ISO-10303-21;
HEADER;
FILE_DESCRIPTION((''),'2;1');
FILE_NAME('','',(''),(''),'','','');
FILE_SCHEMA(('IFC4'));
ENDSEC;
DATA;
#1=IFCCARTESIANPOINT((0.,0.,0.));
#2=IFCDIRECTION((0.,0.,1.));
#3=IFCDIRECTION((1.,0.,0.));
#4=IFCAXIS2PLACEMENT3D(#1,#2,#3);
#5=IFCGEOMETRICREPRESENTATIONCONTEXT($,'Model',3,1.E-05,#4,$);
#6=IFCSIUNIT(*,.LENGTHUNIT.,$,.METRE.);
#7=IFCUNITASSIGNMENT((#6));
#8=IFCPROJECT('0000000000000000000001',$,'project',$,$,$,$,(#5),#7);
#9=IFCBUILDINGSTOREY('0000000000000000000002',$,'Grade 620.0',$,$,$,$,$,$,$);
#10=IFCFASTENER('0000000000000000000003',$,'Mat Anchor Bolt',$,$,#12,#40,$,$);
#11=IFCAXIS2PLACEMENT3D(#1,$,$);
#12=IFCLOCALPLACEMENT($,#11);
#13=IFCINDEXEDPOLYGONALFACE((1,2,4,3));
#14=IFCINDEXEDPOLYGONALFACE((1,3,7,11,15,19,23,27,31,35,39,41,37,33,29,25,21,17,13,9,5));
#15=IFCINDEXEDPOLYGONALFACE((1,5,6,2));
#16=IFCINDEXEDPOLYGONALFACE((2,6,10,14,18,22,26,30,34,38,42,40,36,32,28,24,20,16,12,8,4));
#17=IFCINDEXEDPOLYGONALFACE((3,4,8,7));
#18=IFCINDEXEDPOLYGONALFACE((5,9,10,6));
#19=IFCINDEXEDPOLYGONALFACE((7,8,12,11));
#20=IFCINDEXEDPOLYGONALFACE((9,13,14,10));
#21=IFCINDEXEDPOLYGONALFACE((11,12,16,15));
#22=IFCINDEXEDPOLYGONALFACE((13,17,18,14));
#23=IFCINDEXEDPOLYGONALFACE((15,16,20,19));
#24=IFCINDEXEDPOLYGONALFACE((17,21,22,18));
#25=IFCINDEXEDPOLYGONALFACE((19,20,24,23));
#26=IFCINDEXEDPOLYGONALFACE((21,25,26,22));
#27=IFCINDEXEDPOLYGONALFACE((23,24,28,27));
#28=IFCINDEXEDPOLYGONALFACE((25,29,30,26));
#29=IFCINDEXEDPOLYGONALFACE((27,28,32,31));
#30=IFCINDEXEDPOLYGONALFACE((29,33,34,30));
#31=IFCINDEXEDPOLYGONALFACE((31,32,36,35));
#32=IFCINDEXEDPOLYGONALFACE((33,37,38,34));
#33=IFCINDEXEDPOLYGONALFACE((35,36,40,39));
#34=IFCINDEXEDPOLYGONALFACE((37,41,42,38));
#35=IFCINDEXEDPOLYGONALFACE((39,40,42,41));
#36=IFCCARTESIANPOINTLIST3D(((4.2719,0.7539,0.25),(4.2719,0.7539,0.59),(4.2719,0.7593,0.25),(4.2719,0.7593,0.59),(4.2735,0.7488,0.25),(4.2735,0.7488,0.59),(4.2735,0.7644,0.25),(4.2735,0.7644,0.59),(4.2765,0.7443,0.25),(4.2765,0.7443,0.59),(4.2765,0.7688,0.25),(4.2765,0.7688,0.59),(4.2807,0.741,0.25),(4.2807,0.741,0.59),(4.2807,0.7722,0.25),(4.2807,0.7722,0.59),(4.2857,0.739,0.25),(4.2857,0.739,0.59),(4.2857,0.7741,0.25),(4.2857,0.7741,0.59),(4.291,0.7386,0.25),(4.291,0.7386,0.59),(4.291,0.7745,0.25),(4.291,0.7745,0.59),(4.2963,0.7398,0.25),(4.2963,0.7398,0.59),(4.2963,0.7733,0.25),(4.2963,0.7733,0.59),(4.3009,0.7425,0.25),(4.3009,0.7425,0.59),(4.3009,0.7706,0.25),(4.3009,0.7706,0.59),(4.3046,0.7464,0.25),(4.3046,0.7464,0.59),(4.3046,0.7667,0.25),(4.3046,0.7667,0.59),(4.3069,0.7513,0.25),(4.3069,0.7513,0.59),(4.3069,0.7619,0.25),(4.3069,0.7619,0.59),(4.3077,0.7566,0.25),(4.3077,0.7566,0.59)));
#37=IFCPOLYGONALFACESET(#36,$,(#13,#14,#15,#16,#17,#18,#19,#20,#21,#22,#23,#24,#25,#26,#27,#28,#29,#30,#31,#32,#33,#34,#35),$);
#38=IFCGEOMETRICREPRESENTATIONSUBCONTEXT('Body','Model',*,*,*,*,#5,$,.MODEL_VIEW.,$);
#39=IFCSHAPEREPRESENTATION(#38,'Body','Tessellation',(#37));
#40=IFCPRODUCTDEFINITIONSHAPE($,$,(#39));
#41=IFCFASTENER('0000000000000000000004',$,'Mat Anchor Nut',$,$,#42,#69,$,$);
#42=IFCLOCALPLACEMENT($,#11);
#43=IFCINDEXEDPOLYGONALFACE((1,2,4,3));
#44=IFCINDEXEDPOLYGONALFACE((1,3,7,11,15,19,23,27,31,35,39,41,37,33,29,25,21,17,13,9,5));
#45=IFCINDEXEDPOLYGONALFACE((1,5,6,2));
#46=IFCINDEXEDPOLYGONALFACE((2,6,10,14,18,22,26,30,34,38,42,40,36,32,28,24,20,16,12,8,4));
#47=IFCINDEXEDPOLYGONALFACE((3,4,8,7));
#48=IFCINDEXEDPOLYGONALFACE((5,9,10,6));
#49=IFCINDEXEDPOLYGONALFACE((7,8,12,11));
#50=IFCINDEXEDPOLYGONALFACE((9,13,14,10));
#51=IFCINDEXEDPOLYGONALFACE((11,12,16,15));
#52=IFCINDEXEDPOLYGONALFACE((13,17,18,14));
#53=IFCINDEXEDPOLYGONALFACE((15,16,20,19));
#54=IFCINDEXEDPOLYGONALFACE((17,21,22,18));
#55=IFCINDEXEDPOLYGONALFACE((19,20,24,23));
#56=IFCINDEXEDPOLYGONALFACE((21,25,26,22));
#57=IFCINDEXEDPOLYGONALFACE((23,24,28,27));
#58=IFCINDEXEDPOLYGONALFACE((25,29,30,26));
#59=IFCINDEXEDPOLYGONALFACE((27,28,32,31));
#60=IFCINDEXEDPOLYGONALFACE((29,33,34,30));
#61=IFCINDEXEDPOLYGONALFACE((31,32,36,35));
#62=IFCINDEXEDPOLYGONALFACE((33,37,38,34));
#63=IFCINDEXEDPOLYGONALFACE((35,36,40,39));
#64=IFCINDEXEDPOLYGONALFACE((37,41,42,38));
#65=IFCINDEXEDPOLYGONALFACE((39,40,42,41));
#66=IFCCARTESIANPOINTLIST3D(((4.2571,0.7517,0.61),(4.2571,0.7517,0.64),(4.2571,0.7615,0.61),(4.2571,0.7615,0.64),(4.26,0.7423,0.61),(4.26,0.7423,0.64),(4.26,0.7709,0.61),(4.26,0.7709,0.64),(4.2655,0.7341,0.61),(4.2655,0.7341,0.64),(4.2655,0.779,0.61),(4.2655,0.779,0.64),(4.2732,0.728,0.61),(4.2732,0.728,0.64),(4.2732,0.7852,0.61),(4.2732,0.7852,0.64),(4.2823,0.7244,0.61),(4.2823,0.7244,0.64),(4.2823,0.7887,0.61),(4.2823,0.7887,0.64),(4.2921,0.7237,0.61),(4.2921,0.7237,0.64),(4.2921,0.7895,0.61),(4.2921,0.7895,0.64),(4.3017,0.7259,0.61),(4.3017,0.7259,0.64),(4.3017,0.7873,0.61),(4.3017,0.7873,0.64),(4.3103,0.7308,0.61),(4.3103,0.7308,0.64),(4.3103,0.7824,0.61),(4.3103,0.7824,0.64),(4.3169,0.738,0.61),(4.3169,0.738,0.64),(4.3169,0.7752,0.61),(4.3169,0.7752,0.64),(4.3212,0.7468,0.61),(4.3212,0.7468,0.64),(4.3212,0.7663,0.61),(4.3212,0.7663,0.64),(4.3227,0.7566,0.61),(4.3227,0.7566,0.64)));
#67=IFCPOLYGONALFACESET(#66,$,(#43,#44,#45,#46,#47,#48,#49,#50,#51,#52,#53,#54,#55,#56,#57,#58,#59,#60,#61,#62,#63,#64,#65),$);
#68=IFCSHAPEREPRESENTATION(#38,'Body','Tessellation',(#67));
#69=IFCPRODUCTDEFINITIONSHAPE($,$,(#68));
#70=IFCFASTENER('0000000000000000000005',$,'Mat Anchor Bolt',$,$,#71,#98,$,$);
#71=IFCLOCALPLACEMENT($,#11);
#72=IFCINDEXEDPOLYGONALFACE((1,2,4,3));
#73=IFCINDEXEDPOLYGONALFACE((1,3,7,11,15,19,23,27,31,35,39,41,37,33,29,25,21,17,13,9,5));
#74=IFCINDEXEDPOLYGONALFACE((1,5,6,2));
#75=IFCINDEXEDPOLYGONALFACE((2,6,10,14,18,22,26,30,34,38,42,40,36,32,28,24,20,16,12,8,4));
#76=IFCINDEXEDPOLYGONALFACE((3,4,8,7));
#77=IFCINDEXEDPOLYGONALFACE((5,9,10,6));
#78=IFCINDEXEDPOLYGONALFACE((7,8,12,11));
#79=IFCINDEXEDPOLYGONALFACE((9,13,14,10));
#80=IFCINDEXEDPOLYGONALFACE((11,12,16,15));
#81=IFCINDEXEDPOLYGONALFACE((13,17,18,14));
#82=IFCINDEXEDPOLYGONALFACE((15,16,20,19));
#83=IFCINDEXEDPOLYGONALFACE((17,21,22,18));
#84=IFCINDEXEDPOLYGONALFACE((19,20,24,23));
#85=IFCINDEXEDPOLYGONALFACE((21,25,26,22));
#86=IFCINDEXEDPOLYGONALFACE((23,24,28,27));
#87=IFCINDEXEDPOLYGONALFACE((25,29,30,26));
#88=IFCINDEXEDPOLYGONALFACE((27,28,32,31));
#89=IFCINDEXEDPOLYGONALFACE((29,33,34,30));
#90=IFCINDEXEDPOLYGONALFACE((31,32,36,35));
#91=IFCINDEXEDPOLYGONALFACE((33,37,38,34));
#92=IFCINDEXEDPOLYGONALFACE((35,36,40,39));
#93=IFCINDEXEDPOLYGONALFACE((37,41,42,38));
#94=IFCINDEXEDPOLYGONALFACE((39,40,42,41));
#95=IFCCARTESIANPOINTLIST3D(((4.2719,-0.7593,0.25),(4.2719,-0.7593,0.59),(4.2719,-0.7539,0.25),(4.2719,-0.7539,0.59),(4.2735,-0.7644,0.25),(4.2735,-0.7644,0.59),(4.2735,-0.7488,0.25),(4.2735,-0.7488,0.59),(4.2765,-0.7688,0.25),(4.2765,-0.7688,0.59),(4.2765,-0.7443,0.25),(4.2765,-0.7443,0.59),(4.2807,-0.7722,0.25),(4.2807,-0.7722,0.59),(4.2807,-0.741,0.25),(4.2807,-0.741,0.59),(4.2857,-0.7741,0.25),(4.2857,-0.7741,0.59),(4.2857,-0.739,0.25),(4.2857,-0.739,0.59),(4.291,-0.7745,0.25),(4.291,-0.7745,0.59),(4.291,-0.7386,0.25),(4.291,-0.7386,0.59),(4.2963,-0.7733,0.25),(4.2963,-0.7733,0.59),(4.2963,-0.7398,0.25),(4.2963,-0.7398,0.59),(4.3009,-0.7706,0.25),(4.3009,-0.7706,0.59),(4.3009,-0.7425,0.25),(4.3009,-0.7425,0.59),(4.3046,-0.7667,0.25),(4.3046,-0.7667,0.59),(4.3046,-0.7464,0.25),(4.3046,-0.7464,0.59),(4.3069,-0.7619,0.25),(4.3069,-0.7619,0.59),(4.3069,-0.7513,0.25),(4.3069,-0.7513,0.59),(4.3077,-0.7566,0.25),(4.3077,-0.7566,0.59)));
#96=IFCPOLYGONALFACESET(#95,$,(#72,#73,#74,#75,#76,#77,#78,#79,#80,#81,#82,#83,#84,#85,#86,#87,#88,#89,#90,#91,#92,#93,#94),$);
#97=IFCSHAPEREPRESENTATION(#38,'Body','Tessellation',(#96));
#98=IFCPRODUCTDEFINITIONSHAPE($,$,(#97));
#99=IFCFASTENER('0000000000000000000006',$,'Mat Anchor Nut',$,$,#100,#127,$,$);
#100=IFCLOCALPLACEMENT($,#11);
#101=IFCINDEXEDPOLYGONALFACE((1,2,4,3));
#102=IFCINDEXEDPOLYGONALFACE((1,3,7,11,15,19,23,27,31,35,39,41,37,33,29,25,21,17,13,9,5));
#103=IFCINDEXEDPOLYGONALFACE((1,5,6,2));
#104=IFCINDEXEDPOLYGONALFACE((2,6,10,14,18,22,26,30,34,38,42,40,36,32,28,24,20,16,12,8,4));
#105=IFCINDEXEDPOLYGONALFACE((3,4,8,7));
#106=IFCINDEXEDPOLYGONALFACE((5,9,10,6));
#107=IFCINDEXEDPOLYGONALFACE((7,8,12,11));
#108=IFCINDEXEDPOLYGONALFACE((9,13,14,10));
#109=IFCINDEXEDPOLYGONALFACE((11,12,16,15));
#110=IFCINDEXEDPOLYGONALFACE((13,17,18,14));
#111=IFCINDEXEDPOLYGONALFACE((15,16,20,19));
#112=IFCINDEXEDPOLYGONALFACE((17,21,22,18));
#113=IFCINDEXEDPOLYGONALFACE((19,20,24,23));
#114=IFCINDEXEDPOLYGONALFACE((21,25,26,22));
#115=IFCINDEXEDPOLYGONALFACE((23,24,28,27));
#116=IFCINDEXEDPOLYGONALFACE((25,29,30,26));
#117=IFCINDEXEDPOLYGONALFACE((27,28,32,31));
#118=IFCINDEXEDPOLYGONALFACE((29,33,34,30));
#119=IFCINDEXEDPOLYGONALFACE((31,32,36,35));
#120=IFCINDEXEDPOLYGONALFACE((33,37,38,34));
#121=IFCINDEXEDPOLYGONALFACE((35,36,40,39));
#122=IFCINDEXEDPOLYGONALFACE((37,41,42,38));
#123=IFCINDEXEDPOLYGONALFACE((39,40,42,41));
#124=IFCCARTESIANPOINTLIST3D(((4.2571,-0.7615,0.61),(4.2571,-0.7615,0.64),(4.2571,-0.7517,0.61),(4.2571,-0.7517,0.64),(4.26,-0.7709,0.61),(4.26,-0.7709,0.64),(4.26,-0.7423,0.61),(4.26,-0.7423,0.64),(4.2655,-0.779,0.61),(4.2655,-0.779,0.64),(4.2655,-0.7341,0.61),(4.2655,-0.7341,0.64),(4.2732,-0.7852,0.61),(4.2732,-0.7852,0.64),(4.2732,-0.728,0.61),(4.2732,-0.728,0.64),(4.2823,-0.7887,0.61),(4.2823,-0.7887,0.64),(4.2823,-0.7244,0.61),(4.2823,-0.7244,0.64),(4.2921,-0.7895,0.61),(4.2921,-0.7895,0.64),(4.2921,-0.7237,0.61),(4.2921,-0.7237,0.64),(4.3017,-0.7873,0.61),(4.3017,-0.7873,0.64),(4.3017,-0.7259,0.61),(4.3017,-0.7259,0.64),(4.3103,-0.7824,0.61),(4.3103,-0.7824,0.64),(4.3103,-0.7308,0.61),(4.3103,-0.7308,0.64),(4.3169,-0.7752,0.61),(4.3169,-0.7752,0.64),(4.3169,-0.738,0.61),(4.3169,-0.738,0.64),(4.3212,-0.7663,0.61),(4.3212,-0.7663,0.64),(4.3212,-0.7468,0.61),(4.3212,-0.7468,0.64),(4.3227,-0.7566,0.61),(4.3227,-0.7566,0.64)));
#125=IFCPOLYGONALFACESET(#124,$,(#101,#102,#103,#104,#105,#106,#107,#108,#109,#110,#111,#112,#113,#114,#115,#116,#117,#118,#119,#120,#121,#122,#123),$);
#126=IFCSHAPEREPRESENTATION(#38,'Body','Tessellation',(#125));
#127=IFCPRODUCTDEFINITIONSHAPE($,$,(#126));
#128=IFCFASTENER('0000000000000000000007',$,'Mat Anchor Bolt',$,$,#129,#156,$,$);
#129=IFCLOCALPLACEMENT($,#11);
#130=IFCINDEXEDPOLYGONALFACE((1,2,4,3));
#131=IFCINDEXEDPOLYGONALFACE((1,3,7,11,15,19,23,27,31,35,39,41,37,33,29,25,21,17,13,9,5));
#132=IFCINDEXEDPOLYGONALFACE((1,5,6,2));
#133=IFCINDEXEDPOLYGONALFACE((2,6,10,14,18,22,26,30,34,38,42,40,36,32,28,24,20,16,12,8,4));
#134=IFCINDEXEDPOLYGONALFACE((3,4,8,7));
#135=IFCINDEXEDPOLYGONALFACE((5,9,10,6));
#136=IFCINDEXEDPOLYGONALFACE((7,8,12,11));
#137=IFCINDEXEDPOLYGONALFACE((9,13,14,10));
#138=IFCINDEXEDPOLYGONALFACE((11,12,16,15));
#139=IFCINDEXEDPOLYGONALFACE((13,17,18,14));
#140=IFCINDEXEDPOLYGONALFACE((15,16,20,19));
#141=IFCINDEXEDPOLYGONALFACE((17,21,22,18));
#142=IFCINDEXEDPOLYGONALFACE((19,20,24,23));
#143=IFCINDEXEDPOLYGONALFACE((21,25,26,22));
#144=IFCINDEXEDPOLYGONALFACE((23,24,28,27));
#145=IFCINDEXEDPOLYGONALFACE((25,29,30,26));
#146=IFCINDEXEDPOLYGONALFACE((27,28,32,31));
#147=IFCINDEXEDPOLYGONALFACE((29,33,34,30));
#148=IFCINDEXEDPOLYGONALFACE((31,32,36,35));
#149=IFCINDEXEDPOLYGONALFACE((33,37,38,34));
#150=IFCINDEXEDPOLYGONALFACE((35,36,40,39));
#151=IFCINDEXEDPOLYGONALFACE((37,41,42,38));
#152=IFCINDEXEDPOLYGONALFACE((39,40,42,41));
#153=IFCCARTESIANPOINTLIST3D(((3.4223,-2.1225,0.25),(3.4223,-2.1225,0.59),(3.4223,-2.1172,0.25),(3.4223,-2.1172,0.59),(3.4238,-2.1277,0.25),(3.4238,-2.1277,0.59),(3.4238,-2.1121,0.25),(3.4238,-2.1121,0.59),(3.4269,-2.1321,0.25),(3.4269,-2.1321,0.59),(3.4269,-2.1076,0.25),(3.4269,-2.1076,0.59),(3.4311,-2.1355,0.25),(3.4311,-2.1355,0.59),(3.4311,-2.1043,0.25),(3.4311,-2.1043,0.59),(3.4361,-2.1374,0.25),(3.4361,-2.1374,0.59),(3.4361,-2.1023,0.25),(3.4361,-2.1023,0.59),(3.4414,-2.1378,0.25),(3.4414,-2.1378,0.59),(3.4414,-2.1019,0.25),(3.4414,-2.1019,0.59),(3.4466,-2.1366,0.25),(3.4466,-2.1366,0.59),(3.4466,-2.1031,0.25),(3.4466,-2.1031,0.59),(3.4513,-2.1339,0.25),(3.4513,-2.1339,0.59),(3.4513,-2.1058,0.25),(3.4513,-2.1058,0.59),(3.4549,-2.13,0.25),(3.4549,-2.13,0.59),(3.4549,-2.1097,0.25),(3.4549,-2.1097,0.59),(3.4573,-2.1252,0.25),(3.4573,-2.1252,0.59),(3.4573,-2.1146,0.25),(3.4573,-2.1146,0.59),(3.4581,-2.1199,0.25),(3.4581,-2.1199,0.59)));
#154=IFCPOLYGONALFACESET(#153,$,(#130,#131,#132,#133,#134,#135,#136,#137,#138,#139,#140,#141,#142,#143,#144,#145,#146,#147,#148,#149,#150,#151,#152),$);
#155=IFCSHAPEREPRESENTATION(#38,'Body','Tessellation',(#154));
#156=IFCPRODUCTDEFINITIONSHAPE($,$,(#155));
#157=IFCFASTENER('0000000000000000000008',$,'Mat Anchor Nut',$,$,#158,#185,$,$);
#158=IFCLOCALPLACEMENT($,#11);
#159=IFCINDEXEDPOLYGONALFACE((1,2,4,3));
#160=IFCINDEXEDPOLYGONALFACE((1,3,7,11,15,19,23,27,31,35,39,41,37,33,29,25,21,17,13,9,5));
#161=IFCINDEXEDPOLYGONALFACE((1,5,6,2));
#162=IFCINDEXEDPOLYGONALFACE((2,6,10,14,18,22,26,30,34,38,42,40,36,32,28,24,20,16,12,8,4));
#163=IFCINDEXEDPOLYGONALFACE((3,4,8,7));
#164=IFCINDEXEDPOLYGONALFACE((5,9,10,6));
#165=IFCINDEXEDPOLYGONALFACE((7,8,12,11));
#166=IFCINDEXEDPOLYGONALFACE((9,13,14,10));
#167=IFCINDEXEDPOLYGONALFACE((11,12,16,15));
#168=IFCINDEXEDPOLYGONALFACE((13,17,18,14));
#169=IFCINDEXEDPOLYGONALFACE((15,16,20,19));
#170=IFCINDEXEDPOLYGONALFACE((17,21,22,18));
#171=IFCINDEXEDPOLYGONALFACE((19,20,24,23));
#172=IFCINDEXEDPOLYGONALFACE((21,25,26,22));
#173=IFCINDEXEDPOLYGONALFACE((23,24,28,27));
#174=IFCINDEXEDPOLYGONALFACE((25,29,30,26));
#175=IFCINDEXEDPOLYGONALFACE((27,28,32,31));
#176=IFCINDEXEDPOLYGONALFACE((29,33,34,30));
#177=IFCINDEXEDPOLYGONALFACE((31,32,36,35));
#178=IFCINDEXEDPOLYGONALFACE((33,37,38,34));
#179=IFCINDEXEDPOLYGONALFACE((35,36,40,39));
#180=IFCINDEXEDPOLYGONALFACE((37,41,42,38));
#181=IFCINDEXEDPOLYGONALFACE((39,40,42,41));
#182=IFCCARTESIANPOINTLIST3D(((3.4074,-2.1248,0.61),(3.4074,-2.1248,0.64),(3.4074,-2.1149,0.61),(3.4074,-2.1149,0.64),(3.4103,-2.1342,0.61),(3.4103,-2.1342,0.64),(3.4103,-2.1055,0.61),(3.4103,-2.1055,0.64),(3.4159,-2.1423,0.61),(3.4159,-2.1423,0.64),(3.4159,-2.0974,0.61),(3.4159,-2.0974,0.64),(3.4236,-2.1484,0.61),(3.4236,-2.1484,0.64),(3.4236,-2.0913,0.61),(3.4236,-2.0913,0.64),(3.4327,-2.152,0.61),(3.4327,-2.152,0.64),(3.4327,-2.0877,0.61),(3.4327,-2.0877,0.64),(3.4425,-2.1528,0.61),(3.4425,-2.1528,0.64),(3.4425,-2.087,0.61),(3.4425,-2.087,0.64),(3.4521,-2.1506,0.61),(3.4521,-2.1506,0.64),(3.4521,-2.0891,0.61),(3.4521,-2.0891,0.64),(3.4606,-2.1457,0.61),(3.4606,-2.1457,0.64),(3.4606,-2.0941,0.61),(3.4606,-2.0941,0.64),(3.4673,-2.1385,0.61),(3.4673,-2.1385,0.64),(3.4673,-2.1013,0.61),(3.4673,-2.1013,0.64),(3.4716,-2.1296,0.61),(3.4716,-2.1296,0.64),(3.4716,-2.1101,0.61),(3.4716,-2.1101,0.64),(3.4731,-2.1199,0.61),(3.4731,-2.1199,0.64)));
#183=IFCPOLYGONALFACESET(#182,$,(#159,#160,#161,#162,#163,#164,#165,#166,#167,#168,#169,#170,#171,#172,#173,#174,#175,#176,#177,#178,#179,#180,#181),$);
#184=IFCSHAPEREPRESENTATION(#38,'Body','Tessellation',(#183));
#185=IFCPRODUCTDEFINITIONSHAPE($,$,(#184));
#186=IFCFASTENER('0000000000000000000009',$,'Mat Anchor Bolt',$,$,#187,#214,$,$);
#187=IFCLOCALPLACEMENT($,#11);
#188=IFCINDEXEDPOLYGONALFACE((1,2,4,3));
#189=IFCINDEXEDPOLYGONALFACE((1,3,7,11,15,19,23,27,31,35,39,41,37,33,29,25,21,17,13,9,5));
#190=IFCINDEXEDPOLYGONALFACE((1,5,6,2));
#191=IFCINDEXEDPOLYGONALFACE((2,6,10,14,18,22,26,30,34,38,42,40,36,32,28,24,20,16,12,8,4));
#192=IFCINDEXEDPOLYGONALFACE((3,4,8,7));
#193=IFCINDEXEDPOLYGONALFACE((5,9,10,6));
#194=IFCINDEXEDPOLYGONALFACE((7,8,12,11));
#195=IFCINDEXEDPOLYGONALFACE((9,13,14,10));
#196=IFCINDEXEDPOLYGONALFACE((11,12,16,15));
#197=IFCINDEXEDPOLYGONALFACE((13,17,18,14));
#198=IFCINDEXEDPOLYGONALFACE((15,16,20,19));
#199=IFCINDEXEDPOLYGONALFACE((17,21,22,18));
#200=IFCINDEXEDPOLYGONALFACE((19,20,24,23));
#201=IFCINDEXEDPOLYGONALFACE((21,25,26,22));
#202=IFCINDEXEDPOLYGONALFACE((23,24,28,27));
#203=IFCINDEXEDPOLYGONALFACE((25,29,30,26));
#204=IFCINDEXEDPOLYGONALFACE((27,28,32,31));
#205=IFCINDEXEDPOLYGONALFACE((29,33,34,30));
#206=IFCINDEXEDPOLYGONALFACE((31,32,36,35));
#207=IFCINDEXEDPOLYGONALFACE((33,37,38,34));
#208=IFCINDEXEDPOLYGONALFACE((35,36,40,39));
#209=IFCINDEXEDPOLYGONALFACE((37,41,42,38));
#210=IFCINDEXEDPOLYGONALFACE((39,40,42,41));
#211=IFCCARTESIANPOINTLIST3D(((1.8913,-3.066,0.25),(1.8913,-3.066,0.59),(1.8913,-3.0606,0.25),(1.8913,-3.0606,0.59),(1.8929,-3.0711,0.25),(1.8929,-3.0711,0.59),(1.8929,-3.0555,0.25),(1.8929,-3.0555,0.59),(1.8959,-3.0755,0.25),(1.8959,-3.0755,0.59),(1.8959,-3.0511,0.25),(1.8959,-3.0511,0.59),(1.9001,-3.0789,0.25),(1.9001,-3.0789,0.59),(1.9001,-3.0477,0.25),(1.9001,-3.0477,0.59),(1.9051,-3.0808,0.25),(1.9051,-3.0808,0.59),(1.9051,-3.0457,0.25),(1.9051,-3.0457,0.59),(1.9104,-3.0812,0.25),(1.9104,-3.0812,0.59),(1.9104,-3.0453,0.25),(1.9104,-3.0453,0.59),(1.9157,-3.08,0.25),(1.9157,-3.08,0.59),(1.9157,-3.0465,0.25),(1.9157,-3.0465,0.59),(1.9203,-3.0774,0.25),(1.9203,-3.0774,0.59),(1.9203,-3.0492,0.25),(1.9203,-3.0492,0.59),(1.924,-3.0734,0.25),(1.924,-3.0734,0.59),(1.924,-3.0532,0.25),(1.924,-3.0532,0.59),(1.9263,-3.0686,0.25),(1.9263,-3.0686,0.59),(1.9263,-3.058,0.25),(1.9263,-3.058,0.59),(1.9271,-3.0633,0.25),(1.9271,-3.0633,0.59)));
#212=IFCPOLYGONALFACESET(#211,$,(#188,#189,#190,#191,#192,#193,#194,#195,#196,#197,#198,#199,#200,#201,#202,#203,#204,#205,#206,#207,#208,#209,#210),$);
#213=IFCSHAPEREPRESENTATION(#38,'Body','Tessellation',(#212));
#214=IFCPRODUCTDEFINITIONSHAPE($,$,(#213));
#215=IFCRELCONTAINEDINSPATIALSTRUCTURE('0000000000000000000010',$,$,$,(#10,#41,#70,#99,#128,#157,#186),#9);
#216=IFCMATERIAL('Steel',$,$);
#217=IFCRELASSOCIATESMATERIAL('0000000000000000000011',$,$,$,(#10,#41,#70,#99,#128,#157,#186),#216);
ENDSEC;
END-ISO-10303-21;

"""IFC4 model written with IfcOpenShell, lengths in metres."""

from ifc_helpers import new_model, si_unit, frame, origin_with_axes, place, context, subcontext, project, spatial, circle, extrude, material, element, save


model = new_model("IFC4")

# Units and contexts
model_context = context("Model", 3, precision=1e-05, world=origin_with_axes())
body_context = subcontext(model_context, "Body", "Model", "MODEL_VIEW")
ifc_project = project(units=[si_unit("LENGTHUNIT", "METRE")], contexts=[model_context])

# Storey
storey = spatial("IfcBuildingStorey", Name="Grade 620.0")

# Fasteners
ifc_material_1 = material(Name="Steel")
fastener_1_placement = place(None, frame((4.2897, 0.7566, 0.25), z_axis=(0.0, 0.0, 1.0), x_axis=(1.0, 0.0, 0.0)))
element("IfcFastener", 1, at=fastener_1_placement, inside=storey, material=ifc_material_1, Name="Mat Anchor Bolt", context=body_context, shape_type="SweptSolid", body=[
    extrude(circle(Radius=0.018), origin_with_axes(), (0.0, 0.0, 1.0), 0.34),
])
fastener_2_placement = place(None, frame((4.2897, 0.7566, 0.61), z_axis=(0.0, 0.0, 1.0), x_axis=(1.0, 0.0, 0.0)))
element("IfcFastener", 2, at=fastener_2_placement, inside=storey, material=ifc_material_1, Name="Mat Anchor Nut", context=body_context, shape_type="SweptSolid", body=[
    extrude(circle(Radius=0.033), origin_with_axes(), (0.0, 0.0, 1.0), 0.03),
])
fastener_3_placement = place(None, frame((4.2897, -0.7566, 0.25), z_axis=(0.0, 0.0, 1.0), x_axis=(1.0, 0.0, 0.0)))
element("IfcFastener", 3, at=fastener_3_placement, inside=storey, material=ifc_material_1, Name="Mat Anchor Bolt", context=body_context, shape_type="SweptSolid", body=[
    extrude(circle(Radius=0.018), origin_with_axes(), (0.0, 0.0, 1.0), 0.34),
])
fastener_4_placement = place(None, frame((4.2897, -0.7566, 0.61), z_axis=(0.0, 0.0, 1.0), x_axis=(1.0, 0.0, 0.0)))
element("IfcFastener", 4, at=fastener_4_placement, inside=storey, material=ifc_material_1, Name="Mat Anchor Nut", context=body_context, shape_type="SweptSolid", body=[
    extrude(circle(Radius=0.033), origin_with_axes(), (0.0, 0.0, 1.0), 0.03),
])
fastener_5_placement = place(None, frame((3.4401, -2.1199, 0.25), z_axis=(0.0, 0.0, 1.0), x_axis=(1.0, 0.0, 0.0)))
element("IfcFastener", 5, at=fastener_5_placement, inside=storey, material=ifc_material_1, Name="Mat Anchor Bolt", context=body_context, shape_type="SweptSolid", body=[
    extrude(circle(Radius=0.018), origin_with_axes(), (0.0, 0.0, 1.0), 0.34),
])
fastener_6_placement = place(None, frame((3.4401, -2.1199, 0.61), z_axis=(0.0, 0.0, 1.0), x_axis=(1.0, 0.0, 0.0)))
element("IfcFastener", 6, at=fastener_6_placement, inside=storey, material=ifc_material_1, Name="Mat Anchor Nut", context=body_context, shape_type="SweptSolid", body=[
    extrude(circle(Radius=0.033), origin_with_axes(), (0.0, 0.0, 1.0), 0.03),
])
fastener_7_placement = place(None, frame((1.9091, -3.0633, 0.25), z_axis=(0.0, 0.0, 1.0), x_axis=(1.0, 0.0, 0.0)))
element("IfcFastener", 7, at=fastener_7_placement, inside=storey, material=ifc_material_1, Name="Mat Anchor Bolt", context=body_context, shape_type="SweptSolid", body=[
    extrude(circle(Radius=0.018), origin_with_axes(), (0.0, 0.0, 1.0), 0.34),
])

save(model, "model.ifc")
